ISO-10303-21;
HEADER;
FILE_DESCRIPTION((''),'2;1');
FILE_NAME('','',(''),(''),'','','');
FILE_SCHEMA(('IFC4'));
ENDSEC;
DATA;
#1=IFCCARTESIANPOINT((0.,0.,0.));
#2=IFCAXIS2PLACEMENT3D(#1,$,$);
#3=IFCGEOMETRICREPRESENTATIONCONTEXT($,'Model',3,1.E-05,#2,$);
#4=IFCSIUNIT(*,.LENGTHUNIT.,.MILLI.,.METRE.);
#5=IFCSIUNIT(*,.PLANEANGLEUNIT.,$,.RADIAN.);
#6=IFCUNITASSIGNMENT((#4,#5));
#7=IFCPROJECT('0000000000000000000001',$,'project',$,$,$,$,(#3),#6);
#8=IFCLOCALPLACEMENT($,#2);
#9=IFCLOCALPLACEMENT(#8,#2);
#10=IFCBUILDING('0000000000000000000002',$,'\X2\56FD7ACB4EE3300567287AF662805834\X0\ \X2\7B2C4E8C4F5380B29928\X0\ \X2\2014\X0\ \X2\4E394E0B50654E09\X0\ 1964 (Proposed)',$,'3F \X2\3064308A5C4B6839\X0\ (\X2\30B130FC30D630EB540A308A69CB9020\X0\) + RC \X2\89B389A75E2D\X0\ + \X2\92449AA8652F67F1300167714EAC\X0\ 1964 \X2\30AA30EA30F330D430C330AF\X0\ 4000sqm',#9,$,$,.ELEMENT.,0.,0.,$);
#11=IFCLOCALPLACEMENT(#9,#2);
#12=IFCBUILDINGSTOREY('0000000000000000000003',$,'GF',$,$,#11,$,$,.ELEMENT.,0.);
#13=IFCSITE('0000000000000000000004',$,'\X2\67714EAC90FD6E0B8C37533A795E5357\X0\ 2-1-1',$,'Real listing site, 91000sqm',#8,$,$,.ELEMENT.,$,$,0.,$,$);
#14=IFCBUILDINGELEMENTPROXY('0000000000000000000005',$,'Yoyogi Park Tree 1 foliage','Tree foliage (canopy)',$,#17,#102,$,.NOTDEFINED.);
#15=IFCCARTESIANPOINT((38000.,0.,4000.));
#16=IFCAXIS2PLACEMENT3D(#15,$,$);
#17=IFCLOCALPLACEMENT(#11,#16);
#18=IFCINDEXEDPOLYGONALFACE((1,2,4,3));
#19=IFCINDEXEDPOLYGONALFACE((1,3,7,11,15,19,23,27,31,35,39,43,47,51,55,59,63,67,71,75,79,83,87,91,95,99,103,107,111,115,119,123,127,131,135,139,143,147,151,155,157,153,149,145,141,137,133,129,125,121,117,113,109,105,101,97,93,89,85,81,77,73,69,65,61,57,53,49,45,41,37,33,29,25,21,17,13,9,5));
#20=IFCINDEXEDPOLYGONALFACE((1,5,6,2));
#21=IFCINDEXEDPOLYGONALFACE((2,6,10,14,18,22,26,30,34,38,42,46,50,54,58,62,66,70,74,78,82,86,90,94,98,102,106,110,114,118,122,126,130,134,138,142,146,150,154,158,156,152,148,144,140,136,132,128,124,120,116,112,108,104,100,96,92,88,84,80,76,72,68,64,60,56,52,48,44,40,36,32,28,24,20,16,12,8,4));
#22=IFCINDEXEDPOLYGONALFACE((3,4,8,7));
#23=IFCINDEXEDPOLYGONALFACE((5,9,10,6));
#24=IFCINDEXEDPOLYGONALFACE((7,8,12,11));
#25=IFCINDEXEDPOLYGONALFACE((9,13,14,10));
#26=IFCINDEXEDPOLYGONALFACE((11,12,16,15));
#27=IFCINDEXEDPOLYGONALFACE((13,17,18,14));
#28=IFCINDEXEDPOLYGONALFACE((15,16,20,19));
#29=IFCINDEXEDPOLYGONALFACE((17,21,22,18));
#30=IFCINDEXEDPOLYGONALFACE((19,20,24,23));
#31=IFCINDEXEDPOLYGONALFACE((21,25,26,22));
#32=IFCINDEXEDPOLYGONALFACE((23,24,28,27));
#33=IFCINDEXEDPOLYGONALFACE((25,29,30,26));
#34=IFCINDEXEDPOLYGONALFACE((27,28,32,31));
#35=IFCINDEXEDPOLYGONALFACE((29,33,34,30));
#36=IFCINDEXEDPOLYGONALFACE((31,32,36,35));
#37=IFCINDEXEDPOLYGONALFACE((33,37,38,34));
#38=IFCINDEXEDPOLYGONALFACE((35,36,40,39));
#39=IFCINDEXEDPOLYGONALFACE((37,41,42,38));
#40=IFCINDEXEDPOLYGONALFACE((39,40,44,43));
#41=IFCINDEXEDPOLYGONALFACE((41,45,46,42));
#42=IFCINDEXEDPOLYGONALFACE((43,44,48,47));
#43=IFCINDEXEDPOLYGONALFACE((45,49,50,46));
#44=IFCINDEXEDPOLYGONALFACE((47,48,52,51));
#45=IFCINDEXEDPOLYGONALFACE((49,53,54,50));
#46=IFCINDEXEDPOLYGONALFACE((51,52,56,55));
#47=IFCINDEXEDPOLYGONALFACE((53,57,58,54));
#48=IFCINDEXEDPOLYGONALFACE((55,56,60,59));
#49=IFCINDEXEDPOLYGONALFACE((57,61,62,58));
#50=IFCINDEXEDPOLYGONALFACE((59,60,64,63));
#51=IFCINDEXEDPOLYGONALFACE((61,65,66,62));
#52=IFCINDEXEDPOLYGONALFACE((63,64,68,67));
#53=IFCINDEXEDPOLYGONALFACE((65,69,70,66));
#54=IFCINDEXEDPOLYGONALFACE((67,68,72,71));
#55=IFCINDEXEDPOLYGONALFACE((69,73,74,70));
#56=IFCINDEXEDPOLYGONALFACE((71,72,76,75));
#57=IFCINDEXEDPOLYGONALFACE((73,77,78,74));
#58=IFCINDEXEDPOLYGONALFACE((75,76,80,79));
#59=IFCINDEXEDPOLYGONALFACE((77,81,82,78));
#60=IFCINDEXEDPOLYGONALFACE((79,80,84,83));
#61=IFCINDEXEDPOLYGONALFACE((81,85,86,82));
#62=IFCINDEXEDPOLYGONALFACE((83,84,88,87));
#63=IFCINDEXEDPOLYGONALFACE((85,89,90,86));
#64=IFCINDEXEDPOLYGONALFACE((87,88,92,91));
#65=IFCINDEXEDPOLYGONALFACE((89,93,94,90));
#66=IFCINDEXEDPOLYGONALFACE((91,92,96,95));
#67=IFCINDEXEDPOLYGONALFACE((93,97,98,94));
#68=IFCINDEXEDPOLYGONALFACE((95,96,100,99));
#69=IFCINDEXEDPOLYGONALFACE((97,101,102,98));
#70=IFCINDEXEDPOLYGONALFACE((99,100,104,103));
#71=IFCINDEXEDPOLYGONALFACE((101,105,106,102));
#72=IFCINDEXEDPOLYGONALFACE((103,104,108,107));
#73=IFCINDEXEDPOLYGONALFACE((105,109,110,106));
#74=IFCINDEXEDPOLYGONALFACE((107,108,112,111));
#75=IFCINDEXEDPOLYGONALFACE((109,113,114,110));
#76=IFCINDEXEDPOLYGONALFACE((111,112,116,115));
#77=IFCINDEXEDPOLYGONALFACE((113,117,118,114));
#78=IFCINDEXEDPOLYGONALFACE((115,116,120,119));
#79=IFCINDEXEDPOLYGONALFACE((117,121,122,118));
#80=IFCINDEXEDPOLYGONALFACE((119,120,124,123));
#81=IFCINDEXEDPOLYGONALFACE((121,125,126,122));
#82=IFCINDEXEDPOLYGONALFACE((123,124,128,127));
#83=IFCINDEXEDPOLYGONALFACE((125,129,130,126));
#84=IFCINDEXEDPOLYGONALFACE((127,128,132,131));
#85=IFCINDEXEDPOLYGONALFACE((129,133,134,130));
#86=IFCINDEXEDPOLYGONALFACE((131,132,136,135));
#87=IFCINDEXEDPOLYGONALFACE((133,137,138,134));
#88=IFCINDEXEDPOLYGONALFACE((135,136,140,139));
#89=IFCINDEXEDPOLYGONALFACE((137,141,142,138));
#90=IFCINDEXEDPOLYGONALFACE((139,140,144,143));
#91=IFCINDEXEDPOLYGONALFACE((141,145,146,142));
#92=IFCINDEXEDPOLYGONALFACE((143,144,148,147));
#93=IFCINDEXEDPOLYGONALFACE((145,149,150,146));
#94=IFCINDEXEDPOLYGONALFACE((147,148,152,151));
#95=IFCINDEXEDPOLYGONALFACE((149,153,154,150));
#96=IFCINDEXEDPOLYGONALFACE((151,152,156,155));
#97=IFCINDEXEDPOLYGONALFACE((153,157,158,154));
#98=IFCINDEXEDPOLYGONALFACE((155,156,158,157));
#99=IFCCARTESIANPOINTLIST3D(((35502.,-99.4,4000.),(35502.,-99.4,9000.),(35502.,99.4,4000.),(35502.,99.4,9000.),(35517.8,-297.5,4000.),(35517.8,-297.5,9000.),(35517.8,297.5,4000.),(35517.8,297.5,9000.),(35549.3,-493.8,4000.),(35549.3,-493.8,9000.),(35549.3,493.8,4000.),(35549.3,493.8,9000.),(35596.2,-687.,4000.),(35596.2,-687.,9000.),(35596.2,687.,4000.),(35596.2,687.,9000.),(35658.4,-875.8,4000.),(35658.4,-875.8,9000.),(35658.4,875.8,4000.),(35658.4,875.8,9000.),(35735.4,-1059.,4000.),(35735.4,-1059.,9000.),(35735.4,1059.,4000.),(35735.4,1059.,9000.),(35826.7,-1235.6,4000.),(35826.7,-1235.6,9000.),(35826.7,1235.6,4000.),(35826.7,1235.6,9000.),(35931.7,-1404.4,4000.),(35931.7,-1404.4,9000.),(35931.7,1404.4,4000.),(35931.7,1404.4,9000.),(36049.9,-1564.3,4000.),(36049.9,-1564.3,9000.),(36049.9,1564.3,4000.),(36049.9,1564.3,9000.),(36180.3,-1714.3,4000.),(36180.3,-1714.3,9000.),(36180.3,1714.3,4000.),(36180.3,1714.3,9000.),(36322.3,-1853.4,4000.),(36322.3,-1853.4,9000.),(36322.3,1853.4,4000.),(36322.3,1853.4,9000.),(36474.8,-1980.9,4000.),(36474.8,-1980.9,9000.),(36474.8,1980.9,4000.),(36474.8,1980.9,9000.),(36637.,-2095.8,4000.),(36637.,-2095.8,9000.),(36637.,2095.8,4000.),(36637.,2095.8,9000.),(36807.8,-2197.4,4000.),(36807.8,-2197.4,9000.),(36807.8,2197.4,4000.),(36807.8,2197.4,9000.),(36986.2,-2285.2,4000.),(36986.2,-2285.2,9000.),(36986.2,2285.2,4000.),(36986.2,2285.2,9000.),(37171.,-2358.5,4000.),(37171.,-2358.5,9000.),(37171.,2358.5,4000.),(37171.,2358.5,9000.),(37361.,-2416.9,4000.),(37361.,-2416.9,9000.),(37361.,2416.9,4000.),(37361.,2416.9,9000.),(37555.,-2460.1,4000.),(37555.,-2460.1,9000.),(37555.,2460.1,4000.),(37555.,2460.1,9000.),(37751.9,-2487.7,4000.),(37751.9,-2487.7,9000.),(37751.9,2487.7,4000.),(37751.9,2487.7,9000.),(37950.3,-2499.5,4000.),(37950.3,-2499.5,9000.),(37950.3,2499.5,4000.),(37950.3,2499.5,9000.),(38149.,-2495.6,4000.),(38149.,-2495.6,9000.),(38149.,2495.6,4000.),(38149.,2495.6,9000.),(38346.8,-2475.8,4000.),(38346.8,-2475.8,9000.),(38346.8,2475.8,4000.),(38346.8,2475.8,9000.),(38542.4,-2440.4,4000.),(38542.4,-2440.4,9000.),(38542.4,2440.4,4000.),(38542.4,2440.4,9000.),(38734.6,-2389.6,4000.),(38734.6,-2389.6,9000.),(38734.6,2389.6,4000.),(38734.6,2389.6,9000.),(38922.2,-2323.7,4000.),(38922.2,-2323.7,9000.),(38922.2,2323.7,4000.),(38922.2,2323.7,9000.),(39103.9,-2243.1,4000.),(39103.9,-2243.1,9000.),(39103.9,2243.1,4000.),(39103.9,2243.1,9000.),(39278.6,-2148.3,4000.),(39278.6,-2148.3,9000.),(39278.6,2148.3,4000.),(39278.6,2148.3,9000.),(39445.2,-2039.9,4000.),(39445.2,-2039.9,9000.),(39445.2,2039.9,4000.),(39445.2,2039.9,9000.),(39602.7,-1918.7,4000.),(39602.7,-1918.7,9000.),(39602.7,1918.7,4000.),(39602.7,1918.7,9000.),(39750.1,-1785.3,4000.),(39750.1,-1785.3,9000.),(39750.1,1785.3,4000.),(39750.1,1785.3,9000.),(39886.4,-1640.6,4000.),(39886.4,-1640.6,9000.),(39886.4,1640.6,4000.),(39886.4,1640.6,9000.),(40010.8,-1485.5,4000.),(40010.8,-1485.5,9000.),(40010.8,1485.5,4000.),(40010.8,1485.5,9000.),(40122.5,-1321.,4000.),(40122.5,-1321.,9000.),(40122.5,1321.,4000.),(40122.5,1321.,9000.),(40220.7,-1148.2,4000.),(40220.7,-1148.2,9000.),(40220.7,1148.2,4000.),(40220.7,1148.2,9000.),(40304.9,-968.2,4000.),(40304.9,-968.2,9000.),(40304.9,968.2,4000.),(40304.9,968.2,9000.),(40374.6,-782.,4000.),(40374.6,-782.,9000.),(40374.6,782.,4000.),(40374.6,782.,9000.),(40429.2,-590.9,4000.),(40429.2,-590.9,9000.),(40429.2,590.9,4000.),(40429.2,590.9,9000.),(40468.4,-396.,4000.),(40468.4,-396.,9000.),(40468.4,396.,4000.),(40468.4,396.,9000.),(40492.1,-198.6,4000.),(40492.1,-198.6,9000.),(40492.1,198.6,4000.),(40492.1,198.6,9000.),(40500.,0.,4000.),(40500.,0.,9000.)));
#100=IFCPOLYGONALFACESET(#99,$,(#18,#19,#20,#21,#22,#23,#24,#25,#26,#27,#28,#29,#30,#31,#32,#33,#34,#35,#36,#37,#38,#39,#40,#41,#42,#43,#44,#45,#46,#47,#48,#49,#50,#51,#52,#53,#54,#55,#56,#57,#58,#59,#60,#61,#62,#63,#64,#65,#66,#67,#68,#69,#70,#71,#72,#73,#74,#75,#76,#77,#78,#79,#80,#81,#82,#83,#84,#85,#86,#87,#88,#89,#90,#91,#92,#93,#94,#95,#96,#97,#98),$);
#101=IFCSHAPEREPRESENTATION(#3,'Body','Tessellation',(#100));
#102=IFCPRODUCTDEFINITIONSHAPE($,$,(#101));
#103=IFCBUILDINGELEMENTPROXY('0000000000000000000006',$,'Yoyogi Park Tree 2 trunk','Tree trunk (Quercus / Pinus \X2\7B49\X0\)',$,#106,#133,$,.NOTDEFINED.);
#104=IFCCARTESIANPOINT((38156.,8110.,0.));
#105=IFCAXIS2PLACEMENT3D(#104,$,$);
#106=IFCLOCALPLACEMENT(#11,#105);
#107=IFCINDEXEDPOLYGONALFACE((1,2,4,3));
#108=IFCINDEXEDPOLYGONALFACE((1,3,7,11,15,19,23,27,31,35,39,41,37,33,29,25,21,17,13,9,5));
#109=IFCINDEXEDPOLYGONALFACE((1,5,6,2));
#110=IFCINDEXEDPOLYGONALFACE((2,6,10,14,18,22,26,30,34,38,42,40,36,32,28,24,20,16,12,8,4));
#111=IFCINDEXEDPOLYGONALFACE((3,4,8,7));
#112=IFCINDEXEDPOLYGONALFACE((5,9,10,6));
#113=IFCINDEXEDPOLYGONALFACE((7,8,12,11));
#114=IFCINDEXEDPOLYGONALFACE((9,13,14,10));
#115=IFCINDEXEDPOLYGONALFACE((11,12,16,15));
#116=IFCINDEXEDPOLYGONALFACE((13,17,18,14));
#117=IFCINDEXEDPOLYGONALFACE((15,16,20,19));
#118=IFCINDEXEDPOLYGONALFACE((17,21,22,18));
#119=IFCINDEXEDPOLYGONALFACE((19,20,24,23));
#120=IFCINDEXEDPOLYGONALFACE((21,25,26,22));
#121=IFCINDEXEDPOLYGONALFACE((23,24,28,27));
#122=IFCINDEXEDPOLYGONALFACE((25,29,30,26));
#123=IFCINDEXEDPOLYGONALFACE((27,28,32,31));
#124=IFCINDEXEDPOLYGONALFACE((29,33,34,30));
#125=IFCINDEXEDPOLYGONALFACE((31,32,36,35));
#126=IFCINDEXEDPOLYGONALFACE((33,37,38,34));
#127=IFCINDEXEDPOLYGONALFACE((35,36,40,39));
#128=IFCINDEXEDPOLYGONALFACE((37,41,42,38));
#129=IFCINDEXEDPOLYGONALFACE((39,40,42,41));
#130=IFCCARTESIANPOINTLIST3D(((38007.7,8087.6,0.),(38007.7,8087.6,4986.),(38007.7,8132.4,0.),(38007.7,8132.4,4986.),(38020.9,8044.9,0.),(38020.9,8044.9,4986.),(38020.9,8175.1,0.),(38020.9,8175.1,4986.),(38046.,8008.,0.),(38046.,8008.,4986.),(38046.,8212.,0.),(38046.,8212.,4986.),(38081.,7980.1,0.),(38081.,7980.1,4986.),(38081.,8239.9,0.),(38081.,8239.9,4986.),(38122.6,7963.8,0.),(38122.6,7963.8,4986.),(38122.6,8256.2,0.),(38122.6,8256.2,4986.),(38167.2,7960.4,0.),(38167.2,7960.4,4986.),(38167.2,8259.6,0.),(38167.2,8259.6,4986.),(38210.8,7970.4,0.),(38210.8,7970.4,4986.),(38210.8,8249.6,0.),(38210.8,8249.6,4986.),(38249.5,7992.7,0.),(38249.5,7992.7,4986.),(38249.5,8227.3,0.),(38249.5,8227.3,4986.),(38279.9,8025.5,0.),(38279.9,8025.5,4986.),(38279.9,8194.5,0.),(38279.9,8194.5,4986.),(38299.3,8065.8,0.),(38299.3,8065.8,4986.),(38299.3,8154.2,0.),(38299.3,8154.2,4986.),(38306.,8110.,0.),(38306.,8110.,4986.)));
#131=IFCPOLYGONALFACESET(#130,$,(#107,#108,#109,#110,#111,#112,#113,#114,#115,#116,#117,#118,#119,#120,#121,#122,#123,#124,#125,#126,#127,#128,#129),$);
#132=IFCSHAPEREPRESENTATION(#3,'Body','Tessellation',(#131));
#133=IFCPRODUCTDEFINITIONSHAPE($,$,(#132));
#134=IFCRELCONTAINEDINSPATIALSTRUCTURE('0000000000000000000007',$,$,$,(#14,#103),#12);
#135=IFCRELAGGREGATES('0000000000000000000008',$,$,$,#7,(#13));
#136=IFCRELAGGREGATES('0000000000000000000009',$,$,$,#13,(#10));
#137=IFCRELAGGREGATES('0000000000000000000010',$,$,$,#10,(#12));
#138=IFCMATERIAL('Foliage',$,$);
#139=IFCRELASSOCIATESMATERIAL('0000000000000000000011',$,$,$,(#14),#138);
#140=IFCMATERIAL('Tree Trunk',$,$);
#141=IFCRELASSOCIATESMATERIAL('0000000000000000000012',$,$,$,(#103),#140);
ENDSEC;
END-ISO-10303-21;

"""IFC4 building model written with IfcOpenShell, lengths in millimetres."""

from ifc_helpers import new_model, si_unit, frame, origin, origin_2d, place, context, project, spatial, circle, extrude, material, element, save


model = new_model("IFC4")

# Units and contexts
model_context = context("Model", 3, precision=1e-05, world=origin())
ifc_project = project(units=[si_unit("LENGTHUNIT", "METRE", prefix="MILLI"), si_unit("PLANEANGLEUNIT", "RADIAN")], contexts=[model_context])

# Site, building, storey
site_placement = place(None, origin())
site = spatial("IfcSite", under=ifc_project, at=site_placement, Name="東京都渋谷区神南 2-1-1", ObjectType="Real listing site, 91000sqm", CompositionType="ELEMENT", RefElevation=0.0)
building_placement = place(site_placement, origin())
building = spatial("IfcBuilding", under=site, at=building_placement, Name="国立代々木競技場 第二体育館 — 丹下健三 1964 (Proposed)", ObjectType="3F つり屋根 (ケーブル吊り構造) + RC 観覧席 + 鉄骨支柱、東京 1964 オリンピック 4000sqm", CompositionType="ELEMENT", ElevationOfRefHeight=0.0, ElevationOfTerrain=0.0)
storey_placement = place(building_placement, origin())
storey = spatial("IfcBuildingStorey", under=building, at=storey_placement, Name="GF", CompositionType="ELEMENT", Elevation=0.0)

# Building element proxies
ifc_material_1 = material(Name="Tree Trunk")
ifc_material_2 = material(Name="Foliage")
proxy_1_placement = place(storey_placement, frame((38000.0, 0.0, 4000.0)))
element("IfcBuildingElementProxy", 1, at=proxy_1_placement, inside=storey, material=ifc_material_2, Name="Yoyogi Park Tree 1 foliage", Description="Tree foliage (canopy)", PredefinedType="NOTDEFINED", context=model_context, shape_type="SweptSolid", body=[
    extrude(circle(Radius=2500.0, at=origin_2d()), frame((38000.0, 0.0, 4000.0)), (0.0, 0.0, 1.0), 5000.0),
])
proxy_2_placement = place(storey_placement, frame((38156.0, 8110.0, 0.0)))
element("IfcBuildingElementProxy", 2, at=proxy_2_placement, inside=storey, material=ifc_material_1, Name="Yoyogi Park Tree 2 trunk", Description="Tree trunk (Quercus / Pinus 等)", PredefinedType="NOTDEFINED", context=model_context, shape_type="SweptSolid", body=[
    extrude(circle(Radius=150.0, at=origin_2d()), frame((38156.0, 8110.0, 0.0)), (0.0, 0.0, 1.0), 4986.0),
])

save(model, "model.ifc")
